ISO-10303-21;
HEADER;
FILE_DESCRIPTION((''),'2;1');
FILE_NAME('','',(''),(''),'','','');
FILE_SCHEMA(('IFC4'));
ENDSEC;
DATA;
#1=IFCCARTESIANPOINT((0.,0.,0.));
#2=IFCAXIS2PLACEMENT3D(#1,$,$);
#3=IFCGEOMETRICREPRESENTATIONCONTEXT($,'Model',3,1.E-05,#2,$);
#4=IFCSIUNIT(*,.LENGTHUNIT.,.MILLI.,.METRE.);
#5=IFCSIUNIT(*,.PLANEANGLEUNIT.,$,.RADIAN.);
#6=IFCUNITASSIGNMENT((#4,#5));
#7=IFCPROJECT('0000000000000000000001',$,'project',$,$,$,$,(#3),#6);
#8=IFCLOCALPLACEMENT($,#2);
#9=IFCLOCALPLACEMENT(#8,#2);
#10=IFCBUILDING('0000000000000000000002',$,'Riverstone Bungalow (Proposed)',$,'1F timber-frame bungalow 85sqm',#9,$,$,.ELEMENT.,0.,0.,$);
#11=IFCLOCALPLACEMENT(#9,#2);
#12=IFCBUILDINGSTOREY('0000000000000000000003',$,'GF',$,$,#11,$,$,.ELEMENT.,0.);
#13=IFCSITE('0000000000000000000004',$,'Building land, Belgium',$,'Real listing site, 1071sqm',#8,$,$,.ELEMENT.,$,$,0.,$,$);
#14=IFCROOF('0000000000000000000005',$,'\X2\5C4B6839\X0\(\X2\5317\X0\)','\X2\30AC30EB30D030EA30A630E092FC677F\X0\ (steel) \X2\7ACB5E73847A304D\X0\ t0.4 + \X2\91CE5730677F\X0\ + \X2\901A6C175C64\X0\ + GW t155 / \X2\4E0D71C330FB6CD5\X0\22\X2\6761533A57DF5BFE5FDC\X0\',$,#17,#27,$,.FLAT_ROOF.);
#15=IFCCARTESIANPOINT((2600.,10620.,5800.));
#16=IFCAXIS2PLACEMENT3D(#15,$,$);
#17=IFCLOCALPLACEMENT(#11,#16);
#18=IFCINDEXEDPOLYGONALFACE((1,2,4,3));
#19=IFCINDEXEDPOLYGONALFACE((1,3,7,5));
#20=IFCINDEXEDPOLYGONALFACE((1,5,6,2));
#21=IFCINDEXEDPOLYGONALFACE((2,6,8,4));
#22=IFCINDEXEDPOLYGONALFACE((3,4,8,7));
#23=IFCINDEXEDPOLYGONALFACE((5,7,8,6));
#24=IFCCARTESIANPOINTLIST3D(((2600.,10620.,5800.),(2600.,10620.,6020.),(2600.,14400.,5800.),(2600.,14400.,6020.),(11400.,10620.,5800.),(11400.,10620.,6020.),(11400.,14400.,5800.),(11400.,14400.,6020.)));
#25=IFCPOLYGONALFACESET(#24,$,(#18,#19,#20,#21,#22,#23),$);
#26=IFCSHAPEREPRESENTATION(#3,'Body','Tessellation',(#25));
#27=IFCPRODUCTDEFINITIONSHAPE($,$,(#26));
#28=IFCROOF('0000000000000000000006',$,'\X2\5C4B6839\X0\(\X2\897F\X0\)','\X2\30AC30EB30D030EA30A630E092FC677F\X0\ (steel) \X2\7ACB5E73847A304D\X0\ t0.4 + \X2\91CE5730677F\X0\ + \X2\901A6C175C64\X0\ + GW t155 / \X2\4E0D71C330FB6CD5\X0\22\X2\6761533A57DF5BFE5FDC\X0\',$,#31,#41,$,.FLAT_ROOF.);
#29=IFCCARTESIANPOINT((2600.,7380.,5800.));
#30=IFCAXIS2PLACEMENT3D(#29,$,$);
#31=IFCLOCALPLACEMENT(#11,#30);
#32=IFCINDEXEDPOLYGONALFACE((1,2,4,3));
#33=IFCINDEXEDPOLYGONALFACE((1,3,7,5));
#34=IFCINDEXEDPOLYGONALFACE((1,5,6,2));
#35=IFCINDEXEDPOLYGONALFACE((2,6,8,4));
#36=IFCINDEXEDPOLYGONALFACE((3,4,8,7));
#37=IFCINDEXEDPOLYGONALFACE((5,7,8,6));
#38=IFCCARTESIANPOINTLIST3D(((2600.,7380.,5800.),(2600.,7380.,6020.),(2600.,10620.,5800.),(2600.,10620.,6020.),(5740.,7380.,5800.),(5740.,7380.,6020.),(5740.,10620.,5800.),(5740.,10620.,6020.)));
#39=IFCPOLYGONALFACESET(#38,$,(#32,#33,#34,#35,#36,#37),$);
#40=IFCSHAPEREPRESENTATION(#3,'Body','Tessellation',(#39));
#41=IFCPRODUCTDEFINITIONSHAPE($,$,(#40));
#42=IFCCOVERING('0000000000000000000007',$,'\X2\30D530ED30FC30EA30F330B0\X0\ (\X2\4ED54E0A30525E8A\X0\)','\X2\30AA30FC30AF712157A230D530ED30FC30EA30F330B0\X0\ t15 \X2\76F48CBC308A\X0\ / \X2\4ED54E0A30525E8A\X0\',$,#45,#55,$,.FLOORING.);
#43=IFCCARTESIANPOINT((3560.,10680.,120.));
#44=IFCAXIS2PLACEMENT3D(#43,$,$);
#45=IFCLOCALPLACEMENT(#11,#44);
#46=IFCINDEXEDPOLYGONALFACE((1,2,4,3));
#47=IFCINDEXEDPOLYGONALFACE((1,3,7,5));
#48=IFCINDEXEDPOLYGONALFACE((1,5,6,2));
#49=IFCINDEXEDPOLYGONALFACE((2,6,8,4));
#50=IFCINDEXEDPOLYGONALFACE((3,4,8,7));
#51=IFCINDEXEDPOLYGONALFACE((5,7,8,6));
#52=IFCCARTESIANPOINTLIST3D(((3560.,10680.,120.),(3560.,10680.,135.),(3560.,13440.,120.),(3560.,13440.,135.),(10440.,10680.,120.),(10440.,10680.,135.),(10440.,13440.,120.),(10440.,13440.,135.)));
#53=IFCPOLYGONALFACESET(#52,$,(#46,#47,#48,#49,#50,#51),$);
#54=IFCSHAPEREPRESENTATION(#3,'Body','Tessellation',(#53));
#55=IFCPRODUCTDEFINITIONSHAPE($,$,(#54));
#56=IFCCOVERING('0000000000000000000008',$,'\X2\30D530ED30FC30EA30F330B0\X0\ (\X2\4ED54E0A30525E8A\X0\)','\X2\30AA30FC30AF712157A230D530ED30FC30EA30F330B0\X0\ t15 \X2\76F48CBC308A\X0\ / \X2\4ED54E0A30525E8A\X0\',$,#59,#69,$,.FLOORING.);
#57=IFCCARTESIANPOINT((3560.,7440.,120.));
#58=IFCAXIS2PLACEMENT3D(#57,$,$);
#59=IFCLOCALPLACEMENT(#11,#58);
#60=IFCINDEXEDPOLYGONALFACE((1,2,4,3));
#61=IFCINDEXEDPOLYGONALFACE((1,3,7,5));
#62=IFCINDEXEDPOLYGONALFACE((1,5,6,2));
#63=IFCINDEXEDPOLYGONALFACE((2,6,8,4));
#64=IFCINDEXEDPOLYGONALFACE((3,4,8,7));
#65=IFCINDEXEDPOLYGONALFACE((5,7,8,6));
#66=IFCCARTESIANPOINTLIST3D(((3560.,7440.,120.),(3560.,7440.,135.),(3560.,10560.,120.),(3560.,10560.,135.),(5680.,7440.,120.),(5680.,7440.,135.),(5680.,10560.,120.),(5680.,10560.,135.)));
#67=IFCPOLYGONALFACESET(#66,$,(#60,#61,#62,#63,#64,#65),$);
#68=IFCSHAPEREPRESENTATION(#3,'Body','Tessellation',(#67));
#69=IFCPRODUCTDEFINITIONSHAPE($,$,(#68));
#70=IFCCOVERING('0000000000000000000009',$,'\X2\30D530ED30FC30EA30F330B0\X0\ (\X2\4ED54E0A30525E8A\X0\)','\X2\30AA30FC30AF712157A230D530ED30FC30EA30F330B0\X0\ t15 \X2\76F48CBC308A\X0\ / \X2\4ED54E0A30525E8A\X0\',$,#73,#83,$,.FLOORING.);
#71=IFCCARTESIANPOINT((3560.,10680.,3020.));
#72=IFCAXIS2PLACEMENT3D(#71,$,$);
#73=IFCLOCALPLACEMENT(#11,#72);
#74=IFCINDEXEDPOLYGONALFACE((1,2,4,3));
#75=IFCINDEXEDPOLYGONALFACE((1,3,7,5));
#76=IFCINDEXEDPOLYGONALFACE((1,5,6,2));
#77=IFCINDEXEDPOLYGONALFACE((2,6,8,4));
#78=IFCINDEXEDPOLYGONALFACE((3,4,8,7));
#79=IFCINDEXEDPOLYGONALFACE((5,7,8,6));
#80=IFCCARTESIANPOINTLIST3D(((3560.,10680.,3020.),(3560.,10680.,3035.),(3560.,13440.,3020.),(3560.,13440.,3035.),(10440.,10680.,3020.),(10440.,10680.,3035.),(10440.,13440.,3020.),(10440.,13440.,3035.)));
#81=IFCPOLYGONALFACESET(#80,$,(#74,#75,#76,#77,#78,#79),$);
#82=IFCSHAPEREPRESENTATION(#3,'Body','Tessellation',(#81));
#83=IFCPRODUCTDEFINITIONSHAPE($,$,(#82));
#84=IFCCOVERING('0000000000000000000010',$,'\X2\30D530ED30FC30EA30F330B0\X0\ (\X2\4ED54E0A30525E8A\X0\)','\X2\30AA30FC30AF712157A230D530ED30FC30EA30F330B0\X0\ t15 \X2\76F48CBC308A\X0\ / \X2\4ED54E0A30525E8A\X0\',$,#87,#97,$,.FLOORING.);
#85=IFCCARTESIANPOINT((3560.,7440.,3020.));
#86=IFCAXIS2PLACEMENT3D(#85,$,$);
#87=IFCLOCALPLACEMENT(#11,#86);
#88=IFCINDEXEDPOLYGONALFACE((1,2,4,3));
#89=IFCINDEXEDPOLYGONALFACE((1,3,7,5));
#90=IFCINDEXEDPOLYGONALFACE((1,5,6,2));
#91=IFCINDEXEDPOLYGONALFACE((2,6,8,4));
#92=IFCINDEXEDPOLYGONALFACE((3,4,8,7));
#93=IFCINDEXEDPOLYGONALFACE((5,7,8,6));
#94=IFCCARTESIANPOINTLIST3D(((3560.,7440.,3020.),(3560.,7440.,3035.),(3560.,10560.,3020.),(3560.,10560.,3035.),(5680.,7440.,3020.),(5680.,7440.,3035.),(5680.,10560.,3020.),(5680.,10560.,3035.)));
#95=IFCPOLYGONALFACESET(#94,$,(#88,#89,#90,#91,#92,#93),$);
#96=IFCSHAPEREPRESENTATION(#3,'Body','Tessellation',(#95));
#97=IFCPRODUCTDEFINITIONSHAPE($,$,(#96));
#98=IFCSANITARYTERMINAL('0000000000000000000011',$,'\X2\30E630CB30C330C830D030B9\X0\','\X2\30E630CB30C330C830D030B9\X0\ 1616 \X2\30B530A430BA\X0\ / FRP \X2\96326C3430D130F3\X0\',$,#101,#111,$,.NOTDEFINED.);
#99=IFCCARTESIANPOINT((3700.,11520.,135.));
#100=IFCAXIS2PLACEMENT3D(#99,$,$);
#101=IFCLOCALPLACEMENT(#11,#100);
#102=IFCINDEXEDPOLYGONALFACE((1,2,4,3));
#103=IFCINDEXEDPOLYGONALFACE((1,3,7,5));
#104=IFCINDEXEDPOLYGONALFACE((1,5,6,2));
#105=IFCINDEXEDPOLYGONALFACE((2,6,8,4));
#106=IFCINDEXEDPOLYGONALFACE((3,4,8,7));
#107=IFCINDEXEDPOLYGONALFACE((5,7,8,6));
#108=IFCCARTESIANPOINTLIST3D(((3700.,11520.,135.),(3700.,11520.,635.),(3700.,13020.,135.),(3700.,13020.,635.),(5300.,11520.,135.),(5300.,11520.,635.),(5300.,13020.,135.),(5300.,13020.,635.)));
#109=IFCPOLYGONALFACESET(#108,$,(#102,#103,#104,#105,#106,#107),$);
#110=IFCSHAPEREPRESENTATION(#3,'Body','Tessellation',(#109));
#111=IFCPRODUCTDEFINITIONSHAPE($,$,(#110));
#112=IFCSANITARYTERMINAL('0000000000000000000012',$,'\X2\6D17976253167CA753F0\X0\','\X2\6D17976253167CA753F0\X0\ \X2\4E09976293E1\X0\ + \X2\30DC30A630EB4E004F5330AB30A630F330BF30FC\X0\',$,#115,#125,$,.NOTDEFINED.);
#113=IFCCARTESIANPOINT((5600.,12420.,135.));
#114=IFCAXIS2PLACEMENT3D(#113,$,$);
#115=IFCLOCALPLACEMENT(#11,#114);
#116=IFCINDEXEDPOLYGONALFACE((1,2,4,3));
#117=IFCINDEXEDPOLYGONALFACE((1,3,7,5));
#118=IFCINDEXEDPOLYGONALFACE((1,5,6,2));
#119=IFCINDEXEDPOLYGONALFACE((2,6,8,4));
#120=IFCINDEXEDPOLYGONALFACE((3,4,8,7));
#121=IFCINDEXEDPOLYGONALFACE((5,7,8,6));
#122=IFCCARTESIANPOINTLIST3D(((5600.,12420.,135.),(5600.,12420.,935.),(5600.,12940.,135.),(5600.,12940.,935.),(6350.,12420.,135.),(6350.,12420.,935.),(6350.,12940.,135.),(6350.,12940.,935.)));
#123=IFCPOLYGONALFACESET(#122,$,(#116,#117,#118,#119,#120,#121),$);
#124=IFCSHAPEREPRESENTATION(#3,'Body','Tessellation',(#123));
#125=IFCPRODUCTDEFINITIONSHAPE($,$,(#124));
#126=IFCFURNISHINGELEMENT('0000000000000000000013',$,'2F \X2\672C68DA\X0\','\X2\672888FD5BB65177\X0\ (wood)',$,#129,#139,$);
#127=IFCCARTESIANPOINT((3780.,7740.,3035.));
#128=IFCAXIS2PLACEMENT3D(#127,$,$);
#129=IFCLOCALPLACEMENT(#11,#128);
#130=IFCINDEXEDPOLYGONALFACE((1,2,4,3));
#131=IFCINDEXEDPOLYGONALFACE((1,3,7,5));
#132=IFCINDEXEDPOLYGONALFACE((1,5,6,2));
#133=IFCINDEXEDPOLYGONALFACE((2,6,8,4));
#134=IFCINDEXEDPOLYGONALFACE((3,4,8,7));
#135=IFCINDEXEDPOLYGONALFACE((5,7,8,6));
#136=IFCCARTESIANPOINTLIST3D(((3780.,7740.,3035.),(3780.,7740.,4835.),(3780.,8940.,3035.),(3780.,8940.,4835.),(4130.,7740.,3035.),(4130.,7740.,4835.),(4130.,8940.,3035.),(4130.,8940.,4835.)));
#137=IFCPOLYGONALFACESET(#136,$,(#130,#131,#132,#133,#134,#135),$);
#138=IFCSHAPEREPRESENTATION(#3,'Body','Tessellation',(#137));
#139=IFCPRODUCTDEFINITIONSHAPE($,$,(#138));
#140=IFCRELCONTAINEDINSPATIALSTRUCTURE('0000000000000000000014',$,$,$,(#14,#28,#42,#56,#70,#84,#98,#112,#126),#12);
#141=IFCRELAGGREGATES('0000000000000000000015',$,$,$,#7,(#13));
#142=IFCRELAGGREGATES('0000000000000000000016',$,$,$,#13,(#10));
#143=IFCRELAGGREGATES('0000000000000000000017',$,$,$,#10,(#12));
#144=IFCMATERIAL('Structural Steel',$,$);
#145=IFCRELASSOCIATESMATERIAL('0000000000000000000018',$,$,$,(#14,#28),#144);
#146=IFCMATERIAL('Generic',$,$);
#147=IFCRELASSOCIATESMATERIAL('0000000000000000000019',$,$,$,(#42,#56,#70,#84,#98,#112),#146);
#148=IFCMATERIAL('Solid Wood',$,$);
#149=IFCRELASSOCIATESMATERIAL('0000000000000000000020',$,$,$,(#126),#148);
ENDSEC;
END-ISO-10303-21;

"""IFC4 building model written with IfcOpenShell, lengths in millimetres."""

from ifc_helpers import new_model, si_unit, frame, frame_2d, origin, place, context, project, spatial, rectangle, extrude, material, element, save


model = new_model("IFC4")

# Units and contexts
model_context = context("Model", 3, precision=1e-05, world=origin())
ifc_project = project(units=[si_unit("LENGTHUNIT", "METRE", prefix="MILLI"), si_unit("PLANEANGLEUNIT", "RADIAN")], contexts=[model_context])

# Site, building, storey
site_placement = place(None, origin())
site = spatial("IfcSite", under=ifc_project, at=site_placement, Name="Building land, Belgium", ObjectType="Real listing site, 1071sqm", CompositionType="ELEMENT", RefElevation=0.0)
building_placement = place(site_placement, origin())
building = spatial("IfcBuilding", under=site, at=building_placement, Name="Riverstone Bungalow (Proposed)", ObjectType="1F timber-frame bungalow 85sqm", CompositionType="ELEMENT", ElevationOfRefHeight=0.0, ElevationOfTerrain=0.0)
storey_placement = place(building_placement, origin())
storey = spatial("IfcBuildingStorey", under=building, at=storey_placement, Name="GF", CompositionType="ELEMENT", Elevation=0.0)

# Shared definitions
ifc_material_1 = material(Name="Solid Wood")

# Roofs
ifc_material_2 = material(Name="Structural Steel")
for number, where, name in (
    (1, (2600.0, 10620.0, 5800.0), "屋根(北)"),
):
    element("IfcRoof", number, at=place(storey_placement, frame(where)), inside=storey, material=ifc_material_2, Name=name, Description="ガルバリウム鋼板 (steel) 立平葺き t0.4 + 野地板 + 通気層 + GW t155 / 不燃・法22条区域対応", PredefinedType="FLAT_ROOF", context=model_context, shape_type="SweptSolid", body=[
        extrude(rectangle(XDim=8800.0, YDim=3780.0, at=frame_2d((4400.0, 1890.0))), frame((2600.0, 10620.0, 5800.0)), (0.0, 0.0, 1.0), 220.0),
    ])
roof_placement = place(storey_placement, frame((2600.0, 7380.0, 5800.0)))
element("IfcRoof", 2, at=roof_placement, inside=storey, material=ifc_material_2, Name="屋根(西)", Description="ガルバリウム鋼板 (steel) 立平葺き t0.4 + 野地板 + 通気層 + GW t155 / 不燃・法22条区域対応", PredefinedType="FLAT_ROOF", context=model_context, shape_type="SweptSolid", body=[
    extrude(rectangle(XDim=3140.0, YDim=3240.0, at=frame_2d((1570.0, 1620.0))), frame((2600.0, 7380.0, 5800.0)), (0.0, 0.0, 1.0), 220.0),
])

# Coverings
ifc_material_3 = material(Name="Generic")
covering_1_placement = place(storey_placement, frame((3560.0, 10680.0, 120.0)))
element("IfcCovering", 3, at=covering_1_placement, inside=storey, material=ifc_material_3, Name="フローリング (仕上げ床)", Description="オーク無垢フローリング t15 直貼り / 仕上げ床", PredefinedType="FLOORING", context=model_context, shape_type="SweptSolid", body=[
    extrude(rectangle(XDim=6880.0, YDim=2760.0, at=frame_2d((3440.0, 1380.0))), frame((3560.0, 10680.0, 120.0)), (0.0, 0.0, 1.0), 15.0),
])
covering_2_placement = place(storey_placement, frame((3560.0, 7440.0, 120.0)))
element("IfcCovering", 4, at=covering_2_placement, inside=storey, material=ifc_material_3, Name="フローリング (仕上げ床)", Description="オーク無垢フローリング t15 直貼り / 仕上げ床", PredefinedType="FLOORING", context=model_context, shape_type="SweptSolid", body=[
    extrude(rectangle(XDim=2120.0, YDim=3120.0, at=frame_2d((1060.0, 1560.0))), frame((3560.0, 7440.0, 120.0)), (0.0, 0.0, 1.0), 15.0),
])
covering_3_placement = place(storey_placement, frame((3560.0, 10680.0, 3020.0)))
element("IfcCovering", 5, at=covering_3_placement, inside=storey, material=ifc_material_3, Name="フローリング (仕上げ床)", Description="オーク無垢フローリング t15 直貼り / 仕上げ床", PredefinedType="FLOORING", context=model_context, shape_type="SweptSolid", body=[
    extrude(rectangle(XDim=6880.0, YDim=2760.0, at=frame_2d((3440.0, 1380.0))), frame((3560.0, 10680.0, 3020.0)), (0.0, 0.0, 1.0), 15.0),
])
covering_4_placement = place(storey_placement, frame((3560.0, 7440.0, 3020.0)))
element("IfcCovering", 6, at=covering_4_placement, inside=storey, material=ifc_material_3, Name="フローリング (仕上げ床)", Description="オーク無垢フローリング t15 直貼り / 仕上げ床", PredefinedType="FLOORING", context=model_context, shape_type="SweptSolid", body=[
    extrude(rectangle(XDim=2120.0, YDim=3120.0, at=frame_2d((1060.0, 1560.0))), frame((3560.0, 7440.0, 3020.0)), (0.0, 0.0, 1.0), 15.0),
])

# Sanitary terminals
sanitary_terminal_1_placement = place(storey_placement, frame((3700.0, 11520.0, 135.0)))
element("IfcSanitaryTerminal", 7, at=sanitary_terminal_1_placement, inside=storey, material=ifc_material_3, Name="ユニットバス", Description="ユニットバス 1616 サイズ / FRP 防水パン", PredefinedType="NOTDEFINED", context=model_context, shape_type="SweptSolid", body=[
    extrude(rectangle(XDim=1600.0, YDim=1500.0, at=frame_2d((800.0, 750.0))), frame((3700.0, 11520.0, 135.0)), (0.0, 0.0, 1.0), 500.0),
])
sanitary_terminal_2_placement = place(storey_placement, frame((5600.0, 12420.0, 135.0)))
element("IfcSanitaryTerminal", 8, at=sanitary_terminal_2_placement, inside=storey, material=ifc_material_3, Name="洗面化粧台", Description="洗面化粧台 三面鏡 + ボウル一体カウンター", PredefinedType="NOTDEFINED", context=model_context, shape_type="SweptSolid", body=[
    extrude(rectangle(XDim=750.0, YDim=520.0, at=frame_2d((375.0, 260.0))), frame((5600.0, 12420.0, 135.0)), (0.0, 0.0, 1.0), 800.0),
])

# Furnishing element
furnishing_placement = place(storey_placement, frame((3780.0, 7740.0, 3035.0)))
element("IfcFurnishingElement", 9, at=furnishing_placement, inside=storey, material=ifc_material_1, Name="2F 本棚", Description="木製家具 (wood)", context=model_context, shape_type="SweptSolid", body=[
    extrude(rectangle(XDim=350.0, YDim=1200.0, at=frame_2d((175.0, 600.0))), frame((3780.0, 7740.0, 3035.0)), (0.0, 0.0, 1.0), 1800.0),
])

save(model, "model.ifc")
